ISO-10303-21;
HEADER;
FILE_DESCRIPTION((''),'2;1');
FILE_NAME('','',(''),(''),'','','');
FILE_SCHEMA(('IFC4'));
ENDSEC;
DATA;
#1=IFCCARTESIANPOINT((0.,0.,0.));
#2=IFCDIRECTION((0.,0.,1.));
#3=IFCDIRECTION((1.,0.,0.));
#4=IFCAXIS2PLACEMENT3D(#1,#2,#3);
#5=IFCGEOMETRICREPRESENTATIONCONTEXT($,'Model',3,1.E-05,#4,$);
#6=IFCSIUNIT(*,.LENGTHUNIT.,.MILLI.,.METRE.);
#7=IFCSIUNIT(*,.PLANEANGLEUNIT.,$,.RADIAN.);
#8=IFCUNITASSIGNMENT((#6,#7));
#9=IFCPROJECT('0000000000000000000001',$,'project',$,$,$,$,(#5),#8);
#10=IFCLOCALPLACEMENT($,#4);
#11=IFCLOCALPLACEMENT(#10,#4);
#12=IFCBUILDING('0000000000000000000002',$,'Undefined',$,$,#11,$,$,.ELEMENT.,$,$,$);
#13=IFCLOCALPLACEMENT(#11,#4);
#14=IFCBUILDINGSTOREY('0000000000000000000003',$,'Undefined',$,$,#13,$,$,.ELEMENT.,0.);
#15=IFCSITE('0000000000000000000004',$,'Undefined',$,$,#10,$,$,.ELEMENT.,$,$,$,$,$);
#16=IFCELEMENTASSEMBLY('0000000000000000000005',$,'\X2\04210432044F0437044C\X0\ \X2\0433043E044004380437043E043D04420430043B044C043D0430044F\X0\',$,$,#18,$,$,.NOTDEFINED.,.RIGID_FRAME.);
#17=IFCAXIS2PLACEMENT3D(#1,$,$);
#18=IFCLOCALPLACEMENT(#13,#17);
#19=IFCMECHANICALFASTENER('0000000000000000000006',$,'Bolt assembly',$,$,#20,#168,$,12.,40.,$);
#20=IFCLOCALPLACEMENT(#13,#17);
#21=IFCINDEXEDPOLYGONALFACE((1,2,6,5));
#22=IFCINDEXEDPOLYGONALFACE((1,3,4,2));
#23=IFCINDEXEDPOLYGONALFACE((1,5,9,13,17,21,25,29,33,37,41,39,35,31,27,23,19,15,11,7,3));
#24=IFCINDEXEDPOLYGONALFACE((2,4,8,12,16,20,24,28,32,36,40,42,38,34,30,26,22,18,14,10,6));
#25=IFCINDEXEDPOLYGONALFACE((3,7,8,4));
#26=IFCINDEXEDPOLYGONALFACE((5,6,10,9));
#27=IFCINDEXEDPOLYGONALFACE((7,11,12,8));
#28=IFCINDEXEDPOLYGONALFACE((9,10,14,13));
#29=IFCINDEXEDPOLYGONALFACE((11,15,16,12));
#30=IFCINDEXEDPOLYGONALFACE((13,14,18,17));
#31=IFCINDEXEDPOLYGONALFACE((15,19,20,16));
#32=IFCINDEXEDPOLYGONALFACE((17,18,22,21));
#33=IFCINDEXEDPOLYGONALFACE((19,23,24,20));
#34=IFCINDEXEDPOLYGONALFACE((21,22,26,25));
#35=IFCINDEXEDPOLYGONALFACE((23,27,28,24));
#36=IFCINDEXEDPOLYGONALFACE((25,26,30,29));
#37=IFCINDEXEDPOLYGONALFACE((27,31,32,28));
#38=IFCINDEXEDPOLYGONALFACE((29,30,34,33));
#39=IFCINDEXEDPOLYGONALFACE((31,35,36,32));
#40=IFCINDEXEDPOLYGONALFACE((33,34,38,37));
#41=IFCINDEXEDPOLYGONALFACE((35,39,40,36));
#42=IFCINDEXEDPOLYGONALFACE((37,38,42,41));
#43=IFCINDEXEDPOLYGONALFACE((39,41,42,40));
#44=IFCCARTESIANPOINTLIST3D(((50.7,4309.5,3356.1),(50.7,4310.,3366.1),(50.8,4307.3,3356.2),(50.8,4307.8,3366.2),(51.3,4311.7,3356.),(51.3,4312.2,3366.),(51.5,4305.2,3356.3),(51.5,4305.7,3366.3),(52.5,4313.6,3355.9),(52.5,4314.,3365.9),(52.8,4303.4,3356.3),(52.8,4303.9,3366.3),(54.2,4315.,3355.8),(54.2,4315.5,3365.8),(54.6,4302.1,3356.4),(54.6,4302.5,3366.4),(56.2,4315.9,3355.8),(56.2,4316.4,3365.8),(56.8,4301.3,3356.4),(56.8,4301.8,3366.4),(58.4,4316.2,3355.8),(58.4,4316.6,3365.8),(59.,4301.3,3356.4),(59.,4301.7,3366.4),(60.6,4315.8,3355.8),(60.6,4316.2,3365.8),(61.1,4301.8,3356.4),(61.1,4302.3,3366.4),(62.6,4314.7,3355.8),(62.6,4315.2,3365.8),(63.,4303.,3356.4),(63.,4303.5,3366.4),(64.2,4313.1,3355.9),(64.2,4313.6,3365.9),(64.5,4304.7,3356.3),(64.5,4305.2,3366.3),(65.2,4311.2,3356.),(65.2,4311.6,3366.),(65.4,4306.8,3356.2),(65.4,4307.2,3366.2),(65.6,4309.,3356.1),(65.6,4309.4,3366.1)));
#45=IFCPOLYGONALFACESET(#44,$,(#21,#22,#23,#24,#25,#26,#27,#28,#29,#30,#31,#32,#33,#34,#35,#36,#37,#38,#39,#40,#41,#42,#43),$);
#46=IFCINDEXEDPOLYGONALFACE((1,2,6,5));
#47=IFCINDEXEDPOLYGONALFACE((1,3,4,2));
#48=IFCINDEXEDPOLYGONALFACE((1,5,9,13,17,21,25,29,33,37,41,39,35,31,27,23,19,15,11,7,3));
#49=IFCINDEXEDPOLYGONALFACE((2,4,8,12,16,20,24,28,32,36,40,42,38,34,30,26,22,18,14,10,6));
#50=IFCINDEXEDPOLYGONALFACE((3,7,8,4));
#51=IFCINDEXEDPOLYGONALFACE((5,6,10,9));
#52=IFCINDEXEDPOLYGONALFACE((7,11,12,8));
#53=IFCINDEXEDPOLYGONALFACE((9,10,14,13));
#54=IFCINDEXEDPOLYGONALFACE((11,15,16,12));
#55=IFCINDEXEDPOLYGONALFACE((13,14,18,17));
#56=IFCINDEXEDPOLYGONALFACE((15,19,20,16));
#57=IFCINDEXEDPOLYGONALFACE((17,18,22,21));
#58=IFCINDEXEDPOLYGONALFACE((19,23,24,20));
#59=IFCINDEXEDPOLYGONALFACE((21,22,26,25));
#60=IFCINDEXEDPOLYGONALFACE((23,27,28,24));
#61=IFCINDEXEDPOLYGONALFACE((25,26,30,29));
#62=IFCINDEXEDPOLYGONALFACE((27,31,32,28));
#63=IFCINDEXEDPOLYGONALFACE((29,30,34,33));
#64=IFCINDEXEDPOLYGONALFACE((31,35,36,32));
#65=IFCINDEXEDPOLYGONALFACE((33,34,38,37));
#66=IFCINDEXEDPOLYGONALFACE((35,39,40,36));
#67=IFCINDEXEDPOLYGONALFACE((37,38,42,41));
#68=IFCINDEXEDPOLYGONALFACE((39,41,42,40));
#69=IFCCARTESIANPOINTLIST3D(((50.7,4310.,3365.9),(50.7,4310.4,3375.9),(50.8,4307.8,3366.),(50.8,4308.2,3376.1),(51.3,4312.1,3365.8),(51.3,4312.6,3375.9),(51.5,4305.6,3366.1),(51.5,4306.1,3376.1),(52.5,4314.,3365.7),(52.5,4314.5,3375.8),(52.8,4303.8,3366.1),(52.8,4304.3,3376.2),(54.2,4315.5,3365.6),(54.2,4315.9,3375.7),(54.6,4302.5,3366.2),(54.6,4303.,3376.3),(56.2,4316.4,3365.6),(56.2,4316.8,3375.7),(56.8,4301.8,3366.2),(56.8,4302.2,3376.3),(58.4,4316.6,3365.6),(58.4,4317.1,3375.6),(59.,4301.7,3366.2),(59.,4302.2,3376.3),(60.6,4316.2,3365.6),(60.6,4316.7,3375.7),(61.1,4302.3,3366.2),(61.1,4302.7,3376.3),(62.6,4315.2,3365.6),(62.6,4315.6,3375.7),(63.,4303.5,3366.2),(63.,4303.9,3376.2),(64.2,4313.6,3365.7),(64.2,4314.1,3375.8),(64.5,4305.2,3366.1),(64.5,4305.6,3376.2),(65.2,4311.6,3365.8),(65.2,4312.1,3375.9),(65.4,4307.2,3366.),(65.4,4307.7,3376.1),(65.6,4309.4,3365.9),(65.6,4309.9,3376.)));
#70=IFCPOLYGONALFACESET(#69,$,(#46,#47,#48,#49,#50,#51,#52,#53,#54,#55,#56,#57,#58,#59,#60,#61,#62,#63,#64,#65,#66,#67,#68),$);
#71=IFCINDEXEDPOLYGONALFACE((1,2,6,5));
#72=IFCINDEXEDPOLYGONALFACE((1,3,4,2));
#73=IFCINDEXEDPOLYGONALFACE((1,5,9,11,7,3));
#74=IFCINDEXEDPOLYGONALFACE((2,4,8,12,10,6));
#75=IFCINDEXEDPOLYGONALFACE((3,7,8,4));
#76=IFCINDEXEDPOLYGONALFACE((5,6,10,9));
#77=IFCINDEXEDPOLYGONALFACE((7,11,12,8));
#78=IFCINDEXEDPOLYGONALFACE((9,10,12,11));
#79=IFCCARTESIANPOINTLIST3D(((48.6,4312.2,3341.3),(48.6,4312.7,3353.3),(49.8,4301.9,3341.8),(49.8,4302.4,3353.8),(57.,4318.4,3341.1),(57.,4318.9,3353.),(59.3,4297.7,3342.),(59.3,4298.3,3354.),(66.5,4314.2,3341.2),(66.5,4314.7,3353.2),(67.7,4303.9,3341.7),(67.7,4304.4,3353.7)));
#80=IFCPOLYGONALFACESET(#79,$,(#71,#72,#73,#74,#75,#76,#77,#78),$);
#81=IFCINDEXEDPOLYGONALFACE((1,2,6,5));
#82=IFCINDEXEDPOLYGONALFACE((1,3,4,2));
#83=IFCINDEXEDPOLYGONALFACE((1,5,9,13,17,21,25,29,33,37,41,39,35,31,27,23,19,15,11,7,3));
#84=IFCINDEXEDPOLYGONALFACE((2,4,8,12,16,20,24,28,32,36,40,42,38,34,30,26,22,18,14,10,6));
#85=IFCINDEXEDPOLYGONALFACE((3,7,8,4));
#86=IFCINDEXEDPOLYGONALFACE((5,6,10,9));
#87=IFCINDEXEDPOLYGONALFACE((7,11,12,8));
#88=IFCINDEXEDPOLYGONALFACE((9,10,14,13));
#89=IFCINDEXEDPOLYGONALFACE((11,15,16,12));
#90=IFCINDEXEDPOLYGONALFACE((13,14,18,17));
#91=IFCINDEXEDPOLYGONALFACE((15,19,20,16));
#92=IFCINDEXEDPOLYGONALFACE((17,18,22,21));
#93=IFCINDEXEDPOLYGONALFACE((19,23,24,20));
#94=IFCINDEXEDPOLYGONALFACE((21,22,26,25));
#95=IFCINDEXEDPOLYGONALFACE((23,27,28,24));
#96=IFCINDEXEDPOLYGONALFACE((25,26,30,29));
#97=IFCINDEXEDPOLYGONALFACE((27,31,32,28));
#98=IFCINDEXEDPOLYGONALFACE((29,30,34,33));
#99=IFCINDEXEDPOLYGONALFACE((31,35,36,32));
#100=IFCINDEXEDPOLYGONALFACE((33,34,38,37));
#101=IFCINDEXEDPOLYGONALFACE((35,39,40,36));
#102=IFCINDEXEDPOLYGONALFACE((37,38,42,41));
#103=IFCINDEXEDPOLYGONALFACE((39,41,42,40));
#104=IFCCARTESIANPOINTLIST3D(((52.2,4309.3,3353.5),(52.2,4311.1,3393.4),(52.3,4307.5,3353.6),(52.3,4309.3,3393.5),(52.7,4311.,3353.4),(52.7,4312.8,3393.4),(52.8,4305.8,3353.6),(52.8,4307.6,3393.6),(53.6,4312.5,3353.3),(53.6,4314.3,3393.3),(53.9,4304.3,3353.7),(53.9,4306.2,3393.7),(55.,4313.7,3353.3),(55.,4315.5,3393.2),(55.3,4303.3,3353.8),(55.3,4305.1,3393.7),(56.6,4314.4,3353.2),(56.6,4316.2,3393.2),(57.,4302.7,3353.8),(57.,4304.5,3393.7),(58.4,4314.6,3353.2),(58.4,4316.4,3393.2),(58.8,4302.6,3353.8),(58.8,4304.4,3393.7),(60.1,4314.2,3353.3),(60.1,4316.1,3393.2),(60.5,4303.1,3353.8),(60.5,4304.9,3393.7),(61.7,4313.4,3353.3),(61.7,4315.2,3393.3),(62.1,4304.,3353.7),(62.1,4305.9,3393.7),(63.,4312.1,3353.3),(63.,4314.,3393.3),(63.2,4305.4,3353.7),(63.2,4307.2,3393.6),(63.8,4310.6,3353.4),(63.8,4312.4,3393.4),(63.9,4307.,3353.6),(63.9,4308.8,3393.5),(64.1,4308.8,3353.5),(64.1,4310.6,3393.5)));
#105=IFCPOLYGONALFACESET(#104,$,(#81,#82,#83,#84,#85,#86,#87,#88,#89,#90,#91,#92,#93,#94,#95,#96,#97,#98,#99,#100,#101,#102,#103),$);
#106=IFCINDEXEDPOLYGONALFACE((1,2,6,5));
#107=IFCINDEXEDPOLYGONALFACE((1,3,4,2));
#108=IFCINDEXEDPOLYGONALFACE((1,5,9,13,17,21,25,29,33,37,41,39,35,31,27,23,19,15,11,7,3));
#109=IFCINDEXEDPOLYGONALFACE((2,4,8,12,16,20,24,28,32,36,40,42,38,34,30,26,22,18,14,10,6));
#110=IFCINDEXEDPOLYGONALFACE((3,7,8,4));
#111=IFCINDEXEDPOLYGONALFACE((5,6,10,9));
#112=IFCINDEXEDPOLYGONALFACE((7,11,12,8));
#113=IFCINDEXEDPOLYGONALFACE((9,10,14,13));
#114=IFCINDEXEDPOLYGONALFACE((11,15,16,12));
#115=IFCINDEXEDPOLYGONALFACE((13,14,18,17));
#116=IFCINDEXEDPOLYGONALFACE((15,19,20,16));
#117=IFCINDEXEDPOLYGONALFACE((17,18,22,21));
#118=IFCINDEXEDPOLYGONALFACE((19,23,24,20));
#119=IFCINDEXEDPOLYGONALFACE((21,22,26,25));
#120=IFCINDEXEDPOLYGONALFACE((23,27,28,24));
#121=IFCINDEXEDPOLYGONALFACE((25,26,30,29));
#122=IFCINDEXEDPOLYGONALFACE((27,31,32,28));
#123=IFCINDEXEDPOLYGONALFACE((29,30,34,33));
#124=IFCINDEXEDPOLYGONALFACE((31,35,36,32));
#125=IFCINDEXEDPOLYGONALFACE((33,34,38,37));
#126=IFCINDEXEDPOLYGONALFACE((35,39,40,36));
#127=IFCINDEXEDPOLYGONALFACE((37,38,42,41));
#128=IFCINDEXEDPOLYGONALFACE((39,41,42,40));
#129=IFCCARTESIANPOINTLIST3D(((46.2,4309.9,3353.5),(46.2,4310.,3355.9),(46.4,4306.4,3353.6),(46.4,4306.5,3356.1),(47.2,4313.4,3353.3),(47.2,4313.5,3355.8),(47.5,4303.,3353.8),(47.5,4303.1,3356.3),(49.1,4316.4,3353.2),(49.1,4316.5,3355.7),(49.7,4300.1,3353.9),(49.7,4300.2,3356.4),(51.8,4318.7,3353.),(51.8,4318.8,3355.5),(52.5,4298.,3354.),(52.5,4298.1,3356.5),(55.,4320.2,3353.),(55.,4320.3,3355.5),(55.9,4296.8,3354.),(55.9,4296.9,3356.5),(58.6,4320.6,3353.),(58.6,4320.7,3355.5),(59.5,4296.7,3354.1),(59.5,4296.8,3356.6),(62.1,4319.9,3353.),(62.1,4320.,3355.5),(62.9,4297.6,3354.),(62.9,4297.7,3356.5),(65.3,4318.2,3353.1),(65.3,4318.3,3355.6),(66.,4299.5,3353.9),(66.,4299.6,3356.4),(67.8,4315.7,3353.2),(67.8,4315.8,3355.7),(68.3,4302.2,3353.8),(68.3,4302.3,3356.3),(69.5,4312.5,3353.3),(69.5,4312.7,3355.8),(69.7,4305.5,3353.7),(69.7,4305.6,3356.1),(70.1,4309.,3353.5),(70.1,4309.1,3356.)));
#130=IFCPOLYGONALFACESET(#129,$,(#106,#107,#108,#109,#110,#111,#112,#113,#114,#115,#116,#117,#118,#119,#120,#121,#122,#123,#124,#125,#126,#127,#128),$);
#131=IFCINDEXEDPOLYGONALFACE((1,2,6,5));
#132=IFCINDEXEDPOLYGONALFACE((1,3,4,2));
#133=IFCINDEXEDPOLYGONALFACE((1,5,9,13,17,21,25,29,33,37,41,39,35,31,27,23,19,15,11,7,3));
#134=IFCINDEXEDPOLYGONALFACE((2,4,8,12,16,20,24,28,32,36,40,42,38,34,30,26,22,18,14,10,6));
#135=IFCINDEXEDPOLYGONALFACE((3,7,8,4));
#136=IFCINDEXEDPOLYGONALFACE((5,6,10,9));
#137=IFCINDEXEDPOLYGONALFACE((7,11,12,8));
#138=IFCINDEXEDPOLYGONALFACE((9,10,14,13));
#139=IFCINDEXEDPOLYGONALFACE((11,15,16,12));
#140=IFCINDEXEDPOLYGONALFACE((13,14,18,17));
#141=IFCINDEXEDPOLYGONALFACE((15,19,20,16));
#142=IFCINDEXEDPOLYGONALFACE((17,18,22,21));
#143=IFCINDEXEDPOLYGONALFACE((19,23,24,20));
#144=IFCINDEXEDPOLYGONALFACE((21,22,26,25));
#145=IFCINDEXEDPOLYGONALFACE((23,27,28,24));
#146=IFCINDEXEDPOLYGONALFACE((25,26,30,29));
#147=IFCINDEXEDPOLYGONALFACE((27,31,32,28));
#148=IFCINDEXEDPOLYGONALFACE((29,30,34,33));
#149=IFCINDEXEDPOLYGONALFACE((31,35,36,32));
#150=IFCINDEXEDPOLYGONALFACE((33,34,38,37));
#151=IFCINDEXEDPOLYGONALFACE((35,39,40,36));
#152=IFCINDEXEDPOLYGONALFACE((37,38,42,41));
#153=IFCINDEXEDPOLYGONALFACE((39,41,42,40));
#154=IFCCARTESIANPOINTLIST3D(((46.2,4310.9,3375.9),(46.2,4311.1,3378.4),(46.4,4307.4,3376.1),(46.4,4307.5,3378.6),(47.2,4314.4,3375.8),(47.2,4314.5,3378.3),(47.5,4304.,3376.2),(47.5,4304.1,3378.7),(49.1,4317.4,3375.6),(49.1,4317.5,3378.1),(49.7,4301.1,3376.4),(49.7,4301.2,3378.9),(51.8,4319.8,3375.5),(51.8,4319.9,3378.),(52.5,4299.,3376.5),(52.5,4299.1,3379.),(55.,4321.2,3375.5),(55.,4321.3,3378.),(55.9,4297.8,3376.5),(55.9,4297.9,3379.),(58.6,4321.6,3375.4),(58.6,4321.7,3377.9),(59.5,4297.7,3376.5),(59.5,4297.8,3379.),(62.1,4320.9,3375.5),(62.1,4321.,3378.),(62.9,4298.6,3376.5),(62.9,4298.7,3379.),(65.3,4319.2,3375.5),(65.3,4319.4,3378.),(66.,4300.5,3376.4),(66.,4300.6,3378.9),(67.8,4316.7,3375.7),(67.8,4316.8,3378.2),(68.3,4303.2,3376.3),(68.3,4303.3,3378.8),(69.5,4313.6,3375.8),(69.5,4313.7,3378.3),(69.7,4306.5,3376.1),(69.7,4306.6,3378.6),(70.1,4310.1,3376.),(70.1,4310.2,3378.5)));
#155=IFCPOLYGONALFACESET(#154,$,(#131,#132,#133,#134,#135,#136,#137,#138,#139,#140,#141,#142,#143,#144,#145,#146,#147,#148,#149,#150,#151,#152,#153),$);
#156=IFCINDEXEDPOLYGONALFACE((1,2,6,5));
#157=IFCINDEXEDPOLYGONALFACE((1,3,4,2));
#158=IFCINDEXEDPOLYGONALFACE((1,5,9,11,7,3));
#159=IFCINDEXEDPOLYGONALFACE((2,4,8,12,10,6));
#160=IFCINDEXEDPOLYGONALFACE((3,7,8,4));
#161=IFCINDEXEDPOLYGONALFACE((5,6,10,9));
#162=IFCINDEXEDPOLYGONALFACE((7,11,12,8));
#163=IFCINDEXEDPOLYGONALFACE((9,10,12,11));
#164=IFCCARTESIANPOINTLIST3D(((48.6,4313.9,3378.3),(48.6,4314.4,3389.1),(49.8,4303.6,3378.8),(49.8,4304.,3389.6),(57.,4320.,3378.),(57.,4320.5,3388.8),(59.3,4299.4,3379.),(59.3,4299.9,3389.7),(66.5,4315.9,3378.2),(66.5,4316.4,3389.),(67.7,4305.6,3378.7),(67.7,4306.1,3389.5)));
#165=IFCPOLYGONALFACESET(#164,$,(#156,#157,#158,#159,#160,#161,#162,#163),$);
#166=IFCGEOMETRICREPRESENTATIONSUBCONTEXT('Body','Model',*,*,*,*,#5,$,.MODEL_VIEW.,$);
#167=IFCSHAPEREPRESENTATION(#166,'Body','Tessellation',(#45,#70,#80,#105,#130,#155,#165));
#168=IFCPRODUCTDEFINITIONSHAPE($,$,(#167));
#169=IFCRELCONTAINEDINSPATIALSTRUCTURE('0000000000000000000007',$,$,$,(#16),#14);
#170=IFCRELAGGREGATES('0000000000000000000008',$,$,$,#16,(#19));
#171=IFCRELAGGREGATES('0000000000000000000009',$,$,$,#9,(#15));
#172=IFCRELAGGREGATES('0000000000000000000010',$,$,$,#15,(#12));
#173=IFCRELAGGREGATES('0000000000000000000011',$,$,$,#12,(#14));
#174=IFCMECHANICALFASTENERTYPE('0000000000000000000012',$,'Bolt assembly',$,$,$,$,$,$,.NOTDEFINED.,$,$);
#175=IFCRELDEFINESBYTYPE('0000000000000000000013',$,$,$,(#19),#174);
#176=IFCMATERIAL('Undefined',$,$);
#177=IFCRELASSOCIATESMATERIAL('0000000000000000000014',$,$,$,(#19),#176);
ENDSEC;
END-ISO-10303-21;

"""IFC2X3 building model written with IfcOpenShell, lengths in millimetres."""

from ifc_helpers import new_model, si_unit, frame, origin_with_axes, origin_2d_with_axis, place, context, subcontext, project, spatial, polyline, circle, outline, extrude, source, transform, mapped, material, type_object, element, aggregate, save


model = new_model("IFC2X3")

# Units and contexts
model_context = context("Model", 3, precision=1e-05, world=origin_with_axes())
body_context = subcontext(model_context, "Body", "Model", "MODEL_VIEW")
ifc_project = project(units=[si_unit("LENGTHUNIT", "METRE", prefix="MILLI"), si_unit("PLANEANGLEUNIT", "RADIAN")], contexts=[model_context])

# Site, building, storey
site_placement = place(None, origin_with_axes())
site = spatial("IfcSite", under=ifc_project, at=site_placement, Name="Undefined", CompositionType="ELEMENT")
building_placement = place(site_placement, origin_with_axes())
building = spatial("IfcBuilding", under=site, at=building_placement, Name="Undefined", CompositionType="ELEMENT")
storey_placement = place(building_placement, origin_with_axes())
storey = spatial("IfcBuildingStorey", under=building, at=storey_placement, Name="Undefined", CompositionType="ELEMENT", Elevation=0.0)

# Element assembly
assembly_1_placement = place(storey_placement, origin_with_axes())
assembly_1 = element("IfcElementAssembly", 1, at=assembly_1_placement, inside=storey, Name="Связь горизонтальная", AssemblyPlace="NOTDEFINED", PredefinedType="RIGID_FRAME")

# Mechanical fastener
ifc_material_1 = material(Name="Undefined")
mechanical_fastener_type = type_object("IfcMechanicalFastenerType", Name="Bolt assembly")
shared_shape_1 = source(origin_with_axes(), body_context, "Body", "SweptSolid", [
    extrude(circle(Radius=7.5, at=origin_2d_with_axis()), frame((0.0, 0.1, 0.0), z_axis=(0.0, 1.0, 0.0), x_axis=(1.0, 0.0, 0.0)), (0.0, 0.0, 1.0), 10.0),
    extrude(circle(Radius=7.5, at=origin_2d_with_axis()), frame((0.0, 9.9, 0.0), z_axis=(0.0, 1.0, 0.0), x_axis=(1.0, 0.0, 0.0)), (0.0, 0.0, 1.0), 10.1),
    extrude(outline(polyline([(10.4, 0.0), (5.2, 9.0), (-5.2, 9.0), (-10.4, 0.0), (-5.2, -9.0), (5.2, -9.0), (10.4, 0.0)])), frame((0.0, -14.5, 0.0), z_axis=(0.0, 1.0, 0.0), x_axis=(1.0, 0.0, 0.0)), (0.0, 0.0, 1.0), 12.0),
    extrude(circle(Radius=6.0, at=origin_2d_with_axis()), frame((0.0, -2.5, 0.0), z_axis=(0.0, 1.0, 0.0), x_axis=(1.0, 0.0, 0.0)), (0.0, 0.0, 1.0), 40.0),
    extrude(circle(Radius=12.0, at=origin_2d_with_axis()), frame((0.0, -2.5, 0.0), z_axis=(0.0, 1.0, 0.0), x_axis=(1.0, 0.0, 0.0)), (0.0, 0.0, 1.0), 2.5),
    extrude(circle(Radius=12.0, at=origin_2d_with_axis()), frame((0.0, 20.0, 0.0), z_axis=(0.0, 1.0, 0.0), x_axis=(1.0, 0.0, 0.0)), (0.0, 0.0, 1.0), 2.5),
    extrude(outline(polyline([(10.4, 0.0), (5.2, 9.0), (-5.2, 9.0), (-10.4, 0.0), (-5.2, -9.0), (5.2, -9.0), (10.4, 0.0)])), frame((0.0, 22.5, 0.0), z_axis=(0.0, 1.0, 0.0), x_axis=(1.0, 0.0, 0.0)), (0.0, 0.0, 1.0), 10.8),
])
mechanical_fastener_1_placement = place(assembly_1_placement, frame((58.1, 4308.7, 3356.0), z_axis=(0.593795, -0.803786, 0.036536), x_axis=(0.804616, 0.593183, -0.026963)))
mechanical_fastener_1 = element("IfcMechanicalFastener", 2, at=mechanical_fastener_1_placement, type_object=mechanical_fastener_type, material=ifc_material_1, Name="Bolt assembly", NominalDiameter=12.0, NominalLength=40.0, context=body_context, shape_type="MappedRepresentation", body=[
    mapped(shared_shape_1, transform((0.0, 0.0, 0.0))),
])
aggregate(assembly_1, [mechanical_fastener_1])

save(model, "model.ifc")
